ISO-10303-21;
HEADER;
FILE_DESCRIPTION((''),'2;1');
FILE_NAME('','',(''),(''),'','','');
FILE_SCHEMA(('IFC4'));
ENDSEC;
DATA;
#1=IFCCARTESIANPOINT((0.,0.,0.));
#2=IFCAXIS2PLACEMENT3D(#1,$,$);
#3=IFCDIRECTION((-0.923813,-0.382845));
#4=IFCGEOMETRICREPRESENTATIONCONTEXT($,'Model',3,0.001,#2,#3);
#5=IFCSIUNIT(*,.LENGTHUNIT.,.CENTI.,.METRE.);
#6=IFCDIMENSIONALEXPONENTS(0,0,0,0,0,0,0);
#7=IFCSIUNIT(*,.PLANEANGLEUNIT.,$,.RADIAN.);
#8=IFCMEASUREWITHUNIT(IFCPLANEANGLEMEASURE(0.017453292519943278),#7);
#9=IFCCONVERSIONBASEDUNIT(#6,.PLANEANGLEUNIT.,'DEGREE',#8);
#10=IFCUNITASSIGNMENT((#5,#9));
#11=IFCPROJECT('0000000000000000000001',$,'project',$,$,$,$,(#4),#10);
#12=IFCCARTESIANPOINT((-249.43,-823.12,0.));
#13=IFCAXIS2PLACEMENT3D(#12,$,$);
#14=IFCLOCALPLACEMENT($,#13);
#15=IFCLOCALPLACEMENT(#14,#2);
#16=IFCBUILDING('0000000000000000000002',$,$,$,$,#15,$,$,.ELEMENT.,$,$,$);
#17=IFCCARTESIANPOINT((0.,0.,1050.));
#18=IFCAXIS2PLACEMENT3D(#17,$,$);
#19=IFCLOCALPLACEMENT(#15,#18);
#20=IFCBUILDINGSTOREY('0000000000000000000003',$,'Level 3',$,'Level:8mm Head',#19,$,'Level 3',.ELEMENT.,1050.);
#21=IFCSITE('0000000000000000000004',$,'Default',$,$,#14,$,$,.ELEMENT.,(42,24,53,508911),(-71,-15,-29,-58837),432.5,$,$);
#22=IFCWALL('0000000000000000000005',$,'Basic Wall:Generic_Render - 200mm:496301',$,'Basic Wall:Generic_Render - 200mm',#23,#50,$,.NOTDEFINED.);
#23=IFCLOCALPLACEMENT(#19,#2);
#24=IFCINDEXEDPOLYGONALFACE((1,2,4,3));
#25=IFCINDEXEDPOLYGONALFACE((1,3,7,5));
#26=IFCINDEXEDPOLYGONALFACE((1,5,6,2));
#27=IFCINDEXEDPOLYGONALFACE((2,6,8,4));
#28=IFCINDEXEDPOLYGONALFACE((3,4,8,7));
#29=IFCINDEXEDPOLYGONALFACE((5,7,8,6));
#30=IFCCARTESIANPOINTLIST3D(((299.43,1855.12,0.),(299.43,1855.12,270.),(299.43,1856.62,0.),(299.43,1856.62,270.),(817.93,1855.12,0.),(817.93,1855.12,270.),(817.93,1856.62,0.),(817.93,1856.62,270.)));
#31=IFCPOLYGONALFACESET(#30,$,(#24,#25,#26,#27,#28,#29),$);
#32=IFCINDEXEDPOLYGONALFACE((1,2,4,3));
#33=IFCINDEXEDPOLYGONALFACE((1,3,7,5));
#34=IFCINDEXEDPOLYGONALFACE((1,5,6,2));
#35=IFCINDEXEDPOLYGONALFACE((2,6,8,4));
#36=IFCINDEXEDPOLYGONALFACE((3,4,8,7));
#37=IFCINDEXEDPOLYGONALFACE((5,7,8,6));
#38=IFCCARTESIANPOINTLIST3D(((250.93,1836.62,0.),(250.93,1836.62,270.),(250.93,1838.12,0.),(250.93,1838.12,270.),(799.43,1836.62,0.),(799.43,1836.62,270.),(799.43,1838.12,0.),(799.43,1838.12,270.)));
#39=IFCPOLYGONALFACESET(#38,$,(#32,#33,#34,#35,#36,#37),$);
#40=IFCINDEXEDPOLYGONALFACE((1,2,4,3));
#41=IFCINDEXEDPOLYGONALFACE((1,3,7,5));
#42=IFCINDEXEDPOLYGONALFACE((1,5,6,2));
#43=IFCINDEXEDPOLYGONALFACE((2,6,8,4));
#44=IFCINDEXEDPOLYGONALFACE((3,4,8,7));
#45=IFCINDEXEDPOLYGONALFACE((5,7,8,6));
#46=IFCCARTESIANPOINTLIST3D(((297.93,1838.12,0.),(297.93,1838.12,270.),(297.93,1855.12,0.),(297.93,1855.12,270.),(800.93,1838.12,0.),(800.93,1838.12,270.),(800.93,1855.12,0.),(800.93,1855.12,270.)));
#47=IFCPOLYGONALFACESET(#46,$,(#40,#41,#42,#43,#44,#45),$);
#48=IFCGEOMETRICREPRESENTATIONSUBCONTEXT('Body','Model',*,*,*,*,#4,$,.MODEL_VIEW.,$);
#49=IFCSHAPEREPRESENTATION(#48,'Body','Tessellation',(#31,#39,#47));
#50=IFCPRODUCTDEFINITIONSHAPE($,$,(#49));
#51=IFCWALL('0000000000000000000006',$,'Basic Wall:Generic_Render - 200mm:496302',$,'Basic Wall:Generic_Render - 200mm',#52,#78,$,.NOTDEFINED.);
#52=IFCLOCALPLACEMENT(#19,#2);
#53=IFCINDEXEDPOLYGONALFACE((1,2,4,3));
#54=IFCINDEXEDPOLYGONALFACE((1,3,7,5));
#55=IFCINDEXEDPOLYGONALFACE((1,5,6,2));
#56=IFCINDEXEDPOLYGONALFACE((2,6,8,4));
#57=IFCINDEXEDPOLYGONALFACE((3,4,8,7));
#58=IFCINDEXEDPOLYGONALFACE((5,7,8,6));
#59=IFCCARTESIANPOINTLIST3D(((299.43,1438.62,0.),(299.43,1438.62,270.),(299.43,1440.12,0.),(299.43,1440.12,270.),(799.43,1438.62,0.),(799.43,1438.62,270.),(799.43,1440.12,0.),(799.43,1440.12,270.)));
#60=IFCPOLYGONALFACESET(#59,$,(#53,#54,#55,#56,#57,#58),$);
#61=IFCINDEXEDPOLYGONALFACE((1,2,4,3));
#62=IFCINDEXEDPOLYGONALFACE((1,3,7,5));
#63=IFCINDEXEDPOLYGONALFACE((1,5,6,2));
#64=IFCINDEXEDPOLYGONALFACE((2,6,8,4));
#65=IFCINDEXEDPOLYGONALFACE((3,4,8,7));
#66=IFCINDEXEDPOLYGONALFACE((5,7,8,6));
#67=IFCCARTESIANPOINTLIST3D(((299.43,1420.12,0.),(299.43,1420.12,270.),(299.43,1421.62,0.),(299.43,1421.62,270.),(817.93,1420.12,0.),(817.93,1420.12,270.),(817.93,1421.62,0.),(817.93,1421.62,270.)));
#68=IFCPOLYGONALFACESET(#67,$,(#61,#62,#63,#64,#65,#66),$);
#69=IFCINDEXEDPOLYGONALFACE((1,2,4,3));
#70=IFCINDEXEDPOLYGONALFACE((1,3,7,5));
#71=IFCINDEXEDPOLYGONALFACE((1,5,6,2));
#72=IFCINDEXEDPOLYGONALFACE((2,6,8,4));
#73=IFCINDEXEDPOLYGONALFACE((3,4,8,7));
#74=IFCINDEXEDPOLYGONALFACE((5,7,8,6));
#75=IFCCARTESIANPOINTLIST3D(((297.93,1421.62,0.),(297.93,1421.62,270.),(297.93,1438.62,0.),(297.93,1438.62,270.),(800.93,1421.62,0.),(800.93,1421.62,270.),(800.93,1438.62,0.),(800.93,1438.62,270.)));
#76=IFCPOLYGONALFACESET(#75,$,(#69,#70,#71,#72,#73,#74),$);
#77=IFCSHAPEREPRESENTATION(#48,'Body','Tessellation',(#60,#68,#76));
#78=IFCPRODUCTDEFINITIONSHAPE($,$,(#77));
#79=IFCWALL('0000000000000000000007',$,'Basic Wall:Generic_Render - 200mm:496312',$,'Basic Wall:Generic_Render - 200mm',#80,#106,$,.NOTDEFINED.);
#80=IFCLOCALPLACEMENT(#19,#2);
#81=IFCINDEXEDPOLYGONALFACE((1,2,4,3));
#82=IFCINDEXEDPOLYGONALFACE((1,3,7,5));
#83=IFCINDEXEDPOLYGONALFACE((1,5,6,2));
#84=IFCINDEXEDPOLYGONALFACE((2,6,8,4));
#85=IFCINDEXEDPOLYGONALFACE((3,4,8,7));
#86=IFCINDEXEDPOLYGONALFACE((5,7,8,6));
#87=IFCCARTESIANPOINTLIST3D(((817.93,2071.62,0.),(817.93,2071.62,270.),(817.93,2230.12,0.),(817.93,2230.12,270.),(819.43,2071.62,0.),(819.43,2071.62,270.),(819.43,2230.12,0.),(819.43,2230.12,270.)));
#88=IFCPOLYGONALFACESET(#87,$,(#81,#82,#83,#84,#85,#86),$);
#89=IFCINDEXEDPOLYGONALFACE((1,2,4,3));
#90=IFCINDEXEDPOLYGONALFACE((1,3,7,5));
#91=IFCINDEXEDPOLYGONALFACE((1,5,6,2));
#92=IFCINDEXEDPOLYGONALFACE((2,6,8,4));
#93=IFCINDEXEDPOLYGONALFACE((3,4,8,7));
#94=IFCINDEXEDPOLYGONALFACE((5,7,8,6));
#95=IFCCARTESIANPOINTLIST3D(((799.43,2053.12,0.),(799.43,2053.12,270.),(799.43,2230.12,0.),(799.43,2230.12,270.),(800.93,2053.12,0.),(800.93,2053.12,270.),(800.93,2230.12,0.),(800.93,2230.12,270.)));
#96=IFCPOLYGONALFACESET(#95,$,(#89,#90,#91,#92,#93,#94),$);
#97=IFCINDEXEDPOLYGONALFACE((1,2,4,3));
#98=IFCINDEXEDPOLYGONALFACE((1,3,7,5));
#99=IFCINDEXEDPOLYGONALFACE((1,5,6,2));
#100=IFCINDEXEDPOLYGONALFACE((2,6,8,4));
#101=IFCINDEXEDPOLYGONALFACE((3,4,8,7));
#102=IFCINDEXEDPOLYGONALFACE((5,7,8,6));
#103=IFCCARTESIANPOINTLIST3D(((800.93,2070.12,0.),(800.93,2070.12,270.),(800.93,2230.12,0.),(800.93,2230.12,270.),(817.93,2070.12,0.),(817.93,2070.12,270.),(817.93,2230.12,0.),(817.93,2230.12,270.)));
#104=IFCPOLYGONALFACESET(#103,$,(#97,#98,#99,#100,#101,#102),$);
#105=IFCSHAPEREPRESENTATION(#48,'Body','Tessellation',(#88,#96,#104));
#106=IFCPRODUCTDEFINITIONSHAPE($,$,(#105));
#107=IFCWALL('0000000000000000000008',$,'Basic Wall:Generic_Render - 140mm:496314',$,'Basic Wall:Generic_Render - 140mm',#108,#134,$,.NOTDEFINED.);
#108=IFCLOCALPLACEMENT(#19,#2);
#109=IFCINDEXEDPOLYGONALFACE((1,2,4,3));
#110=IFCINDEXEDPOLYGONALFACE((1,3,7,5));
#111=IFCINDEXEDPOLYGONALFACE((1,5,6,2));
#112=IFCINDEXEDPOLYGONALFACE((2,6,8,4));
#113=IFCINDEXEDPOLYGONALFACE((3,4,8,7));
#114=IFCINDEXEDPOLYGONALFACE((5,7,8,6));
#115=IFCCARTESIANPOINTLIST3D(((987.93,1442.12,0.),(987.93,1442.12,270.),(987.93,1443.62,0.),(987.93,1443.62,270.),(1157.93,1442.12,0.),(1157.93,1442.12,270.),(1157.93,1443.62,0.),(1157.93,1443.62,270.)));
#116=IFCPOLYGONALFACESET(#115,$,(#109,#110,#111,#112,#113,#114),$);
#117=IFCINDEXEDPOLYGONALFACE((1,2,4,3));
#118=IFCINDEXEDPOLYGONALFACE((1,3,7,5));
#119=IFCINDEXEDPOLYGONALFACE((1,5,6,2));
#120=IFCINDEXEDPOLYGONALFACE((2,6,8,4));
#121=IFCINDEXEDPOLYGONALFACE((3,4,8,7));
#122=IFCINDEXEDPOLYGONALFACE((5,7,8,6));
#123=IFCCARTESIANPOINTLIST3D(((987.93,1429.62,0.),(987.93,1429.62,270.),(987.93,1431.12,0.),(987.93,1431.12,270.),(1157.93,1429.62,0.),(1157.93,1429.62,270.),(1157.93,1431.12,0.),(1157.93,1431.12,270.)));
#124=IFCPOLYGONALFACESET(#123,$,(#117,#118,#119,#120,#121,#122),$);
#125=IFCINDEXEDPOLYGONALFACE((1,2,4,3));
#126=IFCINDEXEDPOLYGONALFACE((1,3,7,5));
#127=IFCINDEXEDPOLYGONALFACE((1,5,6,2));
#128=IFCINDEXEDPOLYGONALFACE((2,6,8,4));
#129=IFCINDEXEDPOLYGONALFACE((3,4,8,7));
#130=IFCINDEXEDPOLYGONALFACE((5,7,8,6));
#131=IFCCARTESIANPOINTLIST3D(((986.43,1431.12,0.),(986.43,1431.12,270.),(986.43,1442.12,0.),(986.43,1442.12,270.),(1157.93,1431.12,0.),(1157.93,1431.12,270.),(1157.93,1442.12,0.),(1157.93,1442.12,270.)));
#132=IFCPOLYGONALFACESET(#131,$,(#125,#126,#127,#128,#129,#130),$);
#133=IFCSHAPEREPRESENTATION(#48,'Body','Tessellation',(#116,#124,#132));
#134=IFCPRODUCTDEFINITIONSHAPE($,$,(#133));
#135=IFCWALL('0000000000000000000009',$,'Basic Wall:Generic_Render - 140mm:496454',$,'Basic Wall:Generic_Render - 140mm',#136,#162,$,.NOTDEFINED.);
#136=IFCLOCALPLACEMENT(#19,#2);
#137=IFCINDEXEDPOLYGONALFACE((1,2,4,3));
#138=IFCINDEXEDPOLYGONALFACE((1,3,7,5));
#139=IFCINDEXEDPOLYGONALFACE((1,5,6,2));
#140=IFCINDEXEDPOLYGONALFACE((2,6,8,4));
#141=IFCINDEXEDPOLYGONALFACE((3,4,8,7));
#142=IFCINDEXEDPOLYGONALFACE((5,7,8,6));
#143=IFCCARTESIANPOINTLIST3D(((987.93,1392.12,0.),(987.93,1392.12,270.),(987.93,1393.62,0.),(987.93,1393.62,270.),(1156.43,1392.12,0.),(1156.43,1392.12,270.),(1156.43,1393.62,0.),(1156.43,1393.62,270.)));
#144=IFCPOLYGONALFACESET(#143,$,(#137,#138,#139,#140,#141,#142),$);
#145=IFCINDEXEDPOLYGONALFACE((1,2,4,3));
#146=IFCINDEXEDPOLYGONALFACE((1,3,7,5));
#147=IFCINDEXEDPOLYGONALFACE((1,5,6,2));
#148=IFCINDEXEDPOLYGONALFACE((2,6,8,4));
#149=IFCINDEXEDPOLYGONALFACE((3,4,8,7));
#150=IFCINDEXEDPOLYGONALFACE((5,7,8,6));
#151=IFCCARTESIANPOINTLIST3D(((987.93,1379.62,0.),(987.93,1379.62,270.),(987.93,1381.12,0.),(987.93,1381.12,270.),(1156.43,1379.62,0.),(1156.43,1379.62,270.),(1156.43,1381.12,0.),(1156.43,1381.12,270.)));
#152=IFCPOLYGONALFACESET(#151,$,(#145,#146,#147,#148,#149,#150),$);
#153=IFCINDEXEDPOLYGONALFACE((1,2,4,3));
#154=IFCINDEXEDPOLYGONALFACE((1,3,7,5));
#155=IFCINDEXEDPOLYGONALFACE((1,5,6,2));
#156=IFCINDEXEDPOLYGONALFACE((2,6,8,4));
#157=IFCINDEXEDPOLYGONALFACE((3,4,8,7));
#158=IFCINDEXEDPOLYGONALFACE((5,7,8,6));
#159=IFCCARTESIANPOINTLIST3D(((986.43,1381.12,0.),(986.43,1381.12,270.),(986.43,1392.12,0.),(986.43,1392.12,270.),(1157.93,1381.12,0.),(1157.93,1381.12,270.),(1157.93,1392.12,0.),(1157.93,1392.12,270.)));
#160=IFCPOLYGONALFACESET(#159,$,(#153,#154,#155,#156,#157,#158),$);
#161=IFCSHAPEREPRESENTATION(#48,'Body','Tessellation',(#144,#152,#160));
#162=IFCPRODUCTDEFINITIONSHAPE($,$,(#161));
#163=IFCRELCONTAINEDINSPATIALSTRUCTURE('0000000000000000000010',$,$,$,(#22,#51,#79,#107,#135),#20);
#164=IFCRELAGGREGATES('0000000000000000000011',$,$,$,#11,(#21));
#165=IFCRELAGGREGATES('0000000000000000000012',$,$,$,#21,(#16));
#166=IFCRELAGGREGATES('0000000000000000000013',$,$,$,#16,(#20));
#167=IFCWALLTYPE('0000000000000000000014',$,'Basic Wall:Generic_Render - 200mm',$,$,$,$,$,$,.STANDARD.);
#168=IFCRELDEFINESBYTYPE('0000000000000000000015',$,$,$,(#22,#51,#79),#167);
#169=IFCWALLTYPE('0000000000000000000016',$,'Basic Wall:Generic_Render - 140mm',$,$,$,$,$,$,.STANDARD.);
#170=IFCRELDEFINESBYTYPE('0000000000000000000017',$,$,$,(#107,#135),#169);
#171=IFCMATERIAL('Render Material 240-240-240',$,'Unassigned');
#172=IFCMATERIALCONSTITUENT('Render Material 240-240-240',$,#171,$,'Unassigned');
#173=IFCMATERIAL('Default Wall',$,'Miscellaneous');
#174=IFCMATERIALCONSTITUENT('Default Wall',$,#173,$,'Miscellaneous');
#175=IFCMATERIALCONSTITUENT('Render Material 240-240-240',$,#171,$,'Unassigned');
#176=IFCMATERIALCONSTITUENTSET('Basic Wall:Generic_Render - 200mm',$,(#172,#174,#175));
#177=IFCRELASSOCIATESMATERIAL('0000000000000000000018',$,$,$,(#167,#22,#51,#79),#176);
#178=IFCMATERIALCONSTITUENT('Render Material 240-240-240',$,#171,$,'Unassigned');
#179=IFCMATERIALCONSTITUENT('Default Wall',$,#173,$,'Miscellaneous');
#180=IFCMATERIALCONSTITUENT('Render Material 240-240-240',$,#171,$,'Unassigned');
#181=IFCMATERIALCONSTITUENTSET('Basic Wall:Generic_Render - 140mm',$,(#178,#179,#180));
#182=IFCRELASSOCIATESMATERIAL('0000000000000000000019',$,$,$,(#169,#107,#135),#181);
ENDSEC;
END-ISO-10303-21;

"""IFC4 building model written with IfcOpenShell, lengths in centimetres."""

from ifc_helpers import new_model, entity, si_unit, converted_unit, direction, frame, origin, place, context, subcontext, project, spatial, indexed_curve, outline, extrude, material, constituent, constituent_set, type_object, element, save


model = new_model("IFC4")

# Units and contexts
model_context = context("Model", 3, precision=0.001, world=origin(), true_north=direction((-0.923813, -0.382845)))
body_context = subcontext(model_context, "Body", "Model", "MODEL_VIEW")
ifc_project = project(units=[si_unit("LENGTHUNIT", "METRE", prefix="CENTI"), converted_unit("PLANEANGLEUNIT", "DEGREE", entity("IfcPlaneAngleMeasure", 0.017453292519943278), si_unit("PLANEANGLEUNIT", "RADIAN"), dimensions=[0, 0, 0, 0, 0, 0, 0])], contexts=[model_context])

# Site, building, storey
site_placement = place(None, frame((-249.43, -823.12, 0.0)))
site = spatial("IfcSite", under=ifc_project, at=site_placement, Name="Default", CompositionType="ELEMENT", RefLatitude=(42, 24, 53, 508911), RefLongitude=(-71, -15, -29, -58837), RefElevation=432.5)
building_placement = place(site_placement, origin())
building = spatial("IfcBuilding", under=site, at=building_placement, CompositionType="ELEMENT")
storey_placement = place(building_placement, frame((0.0, 0.0, 1050.0)))
storey = spatial("IfcBuildingStorey", under=building, at=storey_placement, Name="Level 3", ObjectType="Level:8mm Head", LongName="Level 3", CompositionType="ELEMENT", Elevation=1050.0)

# Shared definitions
ifc_material_1 = material(Name="Render Material 240-240-240", Category="Unassigned")
ifc_material_2 = material(Name="Default Wall", Category="Miscellaneous")

# Shared definitions
ifc_constituent_1 = constituent(ifc_material_1, Name="Render Material 240-240-240", Category="Unassigned")
ifc_constituent_2 = constituent(ifc_material_2, Name="Default Wall", Category="Miscellaneous")
ifc_constituent_3 = constituent(ifc_material_1, Name="Render Material 240-240-240", Category="Unassigned")
ifc_constituent_set_1 = constituent_set(constituents=[ifc_constituent_1, ifc_constituent_2, ifc_constituent_3], Name="Basic Wall:Generic_Render - 200mm")
wall_type_1 = type_object("IfcWallType", Name="Basic Wall:Generic_Render - 200mm", PredefinedType="STANDARD", material=ifc_constituent_set_1)

# Walls
wall_1_placement = place(storey_placement, frame((799.43, 1846.62, 0.0), z_axis=(0.0, 0.0, 1.0), x_axis=(-1.0, 0.0, 0.0)))
element("IfcWall", 1, at=wall_1_placement, inside=storey, type_object=wall_type_1, material=ifc_constituent_set_1, Name="Basic Wall:Generic_Render - 200mm:496301", ObjectType="Basic Wall:Generic_Render - 200mm", PredefinedType="NOTDEFINED", context=body_context, shape_type="SweptSolid", body=[
    extrude(outline(indexed_curve([(-0.75, -259.25), (0.75, -259.25), (0.75, 259.25), (-0.75, 259.25), (-0.75, -259.25)], self_intersect=False)), frame((240.75, -9.25, 0.0), z_axis=(0.0, 0.0, 1.0), x_axis=(0.0, 1.0, 0.0)), (0.0, 0.0, 1.0), 270.0),
    extrude(outline(indexed_curve([(-0.75, -274.25), (0.75, -274.25), (0.75, 274.25), (-0.75, 274.25), (-0.75, -274.25)], self_intersect=False)), frame((274.25, 9.25, 0.0), z_axis=(0.0, 0.0, 1.0), x_axis=(0.0, -1.0, 0.0)), (0.0, 0.0, 1.0), 270.0),
    extrude(outline(indexed_curve([(-251.5, -8.5), (251.5, -8.5), (251.5, 8.5), (-251.5, 8.5), (-251.5, -8.5)], self_intersect=False)), frame((250.0, 0.0, 0.0)), (0.0, 0.0, 1.0), 270.0),
])
wall_2_placement = place(storey_placement, frame((799.43, 1430.12, 0.0), z_axis=(0.0, 0.0, 1.0), x_axis=(-1.0, 0.0, 0.0)))
element("IfcWall", 2, at=wall_2_placement, inside=storey, type_object=wall_type_1, material=ifc_constituent_set_1, Name="Basic Wall:Generic_Render - 200mm:496302", ObjectType="Basic Wall:Generic_Render - 200mm", PredefinedType="NOTDEFINED", context=body_context, shape_type="SweptSolid", body=[
    extrude(outline(indexed_curve([(-0.75, -250.0), (0.75, -250.0), (0.75, 250.0), (-0.75, 250.0), (-0.75, -250.0)], self_intersect=False)), frame((250.0, -9.25, 0.0), z_axis=(0.0, 0.0, 1.0), x_axis=(0.0, 1.0, 0.0)), (0.0, 0.0, 1.0), 270.0),
    extrude(outline(indexed_curve([(-0.75, -259.25), (0.75, -259.25), (0.75, 259.25), (-0.75, 259.25), (-0.75, -259.25)], self_intersect=False)), frame((240.75, 9.25, 0.0), z_axis=(0.0, 0.0, 1.0), x_axis=(0.0, -1.0, 0.0)), (0.0, 0.0, 1.0), 270.0),
    extrude(outline(indexed_curve([(-251.5, -8.5), (251.5, -8.5), (251.5, 8.5), (-251.5, 8.5), (-251.5, -8.5)], self_intersect=False)), frame((250.0, 0.0, 0.0)), (0.0, 0.0, 1.0), 270.0),
])

# Walls
wall_3_placement = place(storey_placement, frame((809.43, 2071.62, 0.0), z_axis=(0.0, 0.0, 1.0), x_axis=(0.0, 1.0, 0.0)))
element("IfcWall", 3, at=wall_3_placement, inside=storey, type_object=wall_type_1, material=ifc_constituent_set_1, Name="Basic Wall:Generic_Render - 200mm:496312", ObjectType="Basic Wall:Generic_Render - 200mm", PredefinedType="NOTDEFINED", context=body_context, shape_type="SweptSolid", body=[
    extrude(outline(indexed_curve([(-0.75, -79.25), (0.75, -79.25), (0.75, 79.25), (-0.75, 79.25), (-0.75, -79.25)], self_intersect=False)), frame((79.25, -9.25, 0.0), z_axis=(0.0, 0.0, 1.0), x_axis=(0.0, 1.0, 0.0)), (0.0, 0.0, 1.0), 270.0),
    extrude(outline(indexed_curve([(-0.75, -88.5), (0.75, -88.5), (0.75, 88.5), (-0.75, 88.5), (-0.75, -88.5)], self_intersect=False)), frame((70.0, 9.25, 0.0), z_axis=(0.0, 0.0, 1.0), x_axis=(0.0, -1.0, 0.0)), (0.0, 0.0, 1.0), 270.0),
    extrude(outline(indexed_curve([(-80.0, -8.5), (80.0, -8.5), (80.0, 8.5), (-80.0, 8.5), (-80.0, -8.5)], self_intersect=False)), frame((78.5, 0.0, 0.0)), (0.0, 0.0, 1.0), 270.0),
])
ifc_constituent_4 = constituent(ifc_material_1, Name="Render Material 240-240-240", Category="Unassigned")
ifc_constituent_5 = constituent(ifc_material_2, Name="Default Wall", Category="Miscellaneous")
ifc_constituent_6 = constituent(ifc_material_1, Name="Render Material 240-240-240", Category="Unassigned")
ifc_constituent_set_2 = constituent_set(constituents=[ifc_constituent_4, ifc_constituent_5, ifc_constituent_6], Name="Basic Wall:Generic_Render - 140mm")
wall_type_2 = type_object("IfcWallType", Name="Basic Wall:Generic_Render - 140mm", PredefinedType="STANDARD", material=ifc_constituent_set_2)
wall_4_placement = place(storey_placement, frame((1157.93, 1436.62, 0.0), z_axis=(0.0, 0.0, 1.0), x_axis=(-1.0, 0.0, 0.0)))
element("IfcWall", 4, at=wall_4_placement, inside=storey, type_object=wall_type_2, material=ifc_constituent_set_2, Name="Basic Wall:Generic_Render - 140mm:496314", ObjectType="Basic Wall:Generic_Render - 140mm", PredefinedType="NOTDEFINED", context=body_context, shape_type="SweptSolid", body=[
    extrude(outline(indexed_curve([(-0.75, -85.0), (0.75, -85.0), (0.75, 85.0), (-0.75, 85.0), (-0.75, -85.0)], self_intersect=False)), frame((85.0, -6.25, 0.0), z_axis=(0.0, 0.0, 1.0), x_axis=(0.0, 1.0, 0.0)), (0.0, 0.0, 1.0), 270.0),
    extrude(outline(indexed_curve([(-0.75, -85.0), (0.75, -85.0), (0.75, 85.0), (-0.75, 85.0), (-0.75, -85.0)], self_intersect=False)), frame((85.0, 6.25, 0.0), z_axis=(0.0, 0.0, 1.0), x_axis=(0.0, -1.0, 0.0)), (0.0, 0.0, 1.0), 270.0),
    extrude(outline(indexed_curve([(-85.75, -5.5), (85.75, -5.5), (85.75, 5.5), (-85.75, 5.5), (-85.75, -5.5)], self_intersect=False)), frame((85.75, 0.0, 0.0)), (0.0, 0.0, 1.0), 270.0),
])
wall_5_placement = place(storey_placement, frame((1156.43, 1386.62, 0.0), z_axis=(0.0, 0.0, 1.0), x_axis=(-1.0, 0.0, 0.0)))
element("IfcWall", 5, at=wall_5_placement, inside=storey, type_object=wall_type_2, material=ifc_constituent_set_2, Name="Basic Wall:Generic_Render - 140mm:496454", ObjectType="Basic Wall:Generic_Render - 140mm", PredefinedType="NOTDEFINED", context=body_context, shape_type="SweptSolid", body=[
    extrude(outline(indexed_curve([(-0.75, -84.25), (0.75, -84.25), (0.75, 84.25), (-0.75, 84.25), (-0.75, -84.25)], self_intersect=False)), frame((84.25, -6.25, 0.0), z_axis=(0.0, 0.0, 1.0), x_axis=(0.0, 1.0, 0.0)), (0.0, 0.0, 1.0), 270.0),
    extrude(outline(indexed_curve([(-0.75, -84.25), (0.75, -84.25), (0.75, 84.25), (-0.75, 84.25), (-0.75, -84.25)], self_intersect=False)), frame((84.25, 6.25, 0.0), z_axis=(0.0, 0.0, 1.0), x_axis=(0.0, -1.0, 0.0)), (0.0, 0.0, 1.0), 270.0),
    extrude(outline(indexed_curve([(-85.75, -5.5), (85.75, -5.5), (85.75, 5.5), (-85.75, 5.5), (-85.75, -5.5)], self_intersect=False)), frame((84.25, 0.0, 0.0)), (0.0, 0.0, 1.0), 270.0),
])

save(model, "model.ifc")
